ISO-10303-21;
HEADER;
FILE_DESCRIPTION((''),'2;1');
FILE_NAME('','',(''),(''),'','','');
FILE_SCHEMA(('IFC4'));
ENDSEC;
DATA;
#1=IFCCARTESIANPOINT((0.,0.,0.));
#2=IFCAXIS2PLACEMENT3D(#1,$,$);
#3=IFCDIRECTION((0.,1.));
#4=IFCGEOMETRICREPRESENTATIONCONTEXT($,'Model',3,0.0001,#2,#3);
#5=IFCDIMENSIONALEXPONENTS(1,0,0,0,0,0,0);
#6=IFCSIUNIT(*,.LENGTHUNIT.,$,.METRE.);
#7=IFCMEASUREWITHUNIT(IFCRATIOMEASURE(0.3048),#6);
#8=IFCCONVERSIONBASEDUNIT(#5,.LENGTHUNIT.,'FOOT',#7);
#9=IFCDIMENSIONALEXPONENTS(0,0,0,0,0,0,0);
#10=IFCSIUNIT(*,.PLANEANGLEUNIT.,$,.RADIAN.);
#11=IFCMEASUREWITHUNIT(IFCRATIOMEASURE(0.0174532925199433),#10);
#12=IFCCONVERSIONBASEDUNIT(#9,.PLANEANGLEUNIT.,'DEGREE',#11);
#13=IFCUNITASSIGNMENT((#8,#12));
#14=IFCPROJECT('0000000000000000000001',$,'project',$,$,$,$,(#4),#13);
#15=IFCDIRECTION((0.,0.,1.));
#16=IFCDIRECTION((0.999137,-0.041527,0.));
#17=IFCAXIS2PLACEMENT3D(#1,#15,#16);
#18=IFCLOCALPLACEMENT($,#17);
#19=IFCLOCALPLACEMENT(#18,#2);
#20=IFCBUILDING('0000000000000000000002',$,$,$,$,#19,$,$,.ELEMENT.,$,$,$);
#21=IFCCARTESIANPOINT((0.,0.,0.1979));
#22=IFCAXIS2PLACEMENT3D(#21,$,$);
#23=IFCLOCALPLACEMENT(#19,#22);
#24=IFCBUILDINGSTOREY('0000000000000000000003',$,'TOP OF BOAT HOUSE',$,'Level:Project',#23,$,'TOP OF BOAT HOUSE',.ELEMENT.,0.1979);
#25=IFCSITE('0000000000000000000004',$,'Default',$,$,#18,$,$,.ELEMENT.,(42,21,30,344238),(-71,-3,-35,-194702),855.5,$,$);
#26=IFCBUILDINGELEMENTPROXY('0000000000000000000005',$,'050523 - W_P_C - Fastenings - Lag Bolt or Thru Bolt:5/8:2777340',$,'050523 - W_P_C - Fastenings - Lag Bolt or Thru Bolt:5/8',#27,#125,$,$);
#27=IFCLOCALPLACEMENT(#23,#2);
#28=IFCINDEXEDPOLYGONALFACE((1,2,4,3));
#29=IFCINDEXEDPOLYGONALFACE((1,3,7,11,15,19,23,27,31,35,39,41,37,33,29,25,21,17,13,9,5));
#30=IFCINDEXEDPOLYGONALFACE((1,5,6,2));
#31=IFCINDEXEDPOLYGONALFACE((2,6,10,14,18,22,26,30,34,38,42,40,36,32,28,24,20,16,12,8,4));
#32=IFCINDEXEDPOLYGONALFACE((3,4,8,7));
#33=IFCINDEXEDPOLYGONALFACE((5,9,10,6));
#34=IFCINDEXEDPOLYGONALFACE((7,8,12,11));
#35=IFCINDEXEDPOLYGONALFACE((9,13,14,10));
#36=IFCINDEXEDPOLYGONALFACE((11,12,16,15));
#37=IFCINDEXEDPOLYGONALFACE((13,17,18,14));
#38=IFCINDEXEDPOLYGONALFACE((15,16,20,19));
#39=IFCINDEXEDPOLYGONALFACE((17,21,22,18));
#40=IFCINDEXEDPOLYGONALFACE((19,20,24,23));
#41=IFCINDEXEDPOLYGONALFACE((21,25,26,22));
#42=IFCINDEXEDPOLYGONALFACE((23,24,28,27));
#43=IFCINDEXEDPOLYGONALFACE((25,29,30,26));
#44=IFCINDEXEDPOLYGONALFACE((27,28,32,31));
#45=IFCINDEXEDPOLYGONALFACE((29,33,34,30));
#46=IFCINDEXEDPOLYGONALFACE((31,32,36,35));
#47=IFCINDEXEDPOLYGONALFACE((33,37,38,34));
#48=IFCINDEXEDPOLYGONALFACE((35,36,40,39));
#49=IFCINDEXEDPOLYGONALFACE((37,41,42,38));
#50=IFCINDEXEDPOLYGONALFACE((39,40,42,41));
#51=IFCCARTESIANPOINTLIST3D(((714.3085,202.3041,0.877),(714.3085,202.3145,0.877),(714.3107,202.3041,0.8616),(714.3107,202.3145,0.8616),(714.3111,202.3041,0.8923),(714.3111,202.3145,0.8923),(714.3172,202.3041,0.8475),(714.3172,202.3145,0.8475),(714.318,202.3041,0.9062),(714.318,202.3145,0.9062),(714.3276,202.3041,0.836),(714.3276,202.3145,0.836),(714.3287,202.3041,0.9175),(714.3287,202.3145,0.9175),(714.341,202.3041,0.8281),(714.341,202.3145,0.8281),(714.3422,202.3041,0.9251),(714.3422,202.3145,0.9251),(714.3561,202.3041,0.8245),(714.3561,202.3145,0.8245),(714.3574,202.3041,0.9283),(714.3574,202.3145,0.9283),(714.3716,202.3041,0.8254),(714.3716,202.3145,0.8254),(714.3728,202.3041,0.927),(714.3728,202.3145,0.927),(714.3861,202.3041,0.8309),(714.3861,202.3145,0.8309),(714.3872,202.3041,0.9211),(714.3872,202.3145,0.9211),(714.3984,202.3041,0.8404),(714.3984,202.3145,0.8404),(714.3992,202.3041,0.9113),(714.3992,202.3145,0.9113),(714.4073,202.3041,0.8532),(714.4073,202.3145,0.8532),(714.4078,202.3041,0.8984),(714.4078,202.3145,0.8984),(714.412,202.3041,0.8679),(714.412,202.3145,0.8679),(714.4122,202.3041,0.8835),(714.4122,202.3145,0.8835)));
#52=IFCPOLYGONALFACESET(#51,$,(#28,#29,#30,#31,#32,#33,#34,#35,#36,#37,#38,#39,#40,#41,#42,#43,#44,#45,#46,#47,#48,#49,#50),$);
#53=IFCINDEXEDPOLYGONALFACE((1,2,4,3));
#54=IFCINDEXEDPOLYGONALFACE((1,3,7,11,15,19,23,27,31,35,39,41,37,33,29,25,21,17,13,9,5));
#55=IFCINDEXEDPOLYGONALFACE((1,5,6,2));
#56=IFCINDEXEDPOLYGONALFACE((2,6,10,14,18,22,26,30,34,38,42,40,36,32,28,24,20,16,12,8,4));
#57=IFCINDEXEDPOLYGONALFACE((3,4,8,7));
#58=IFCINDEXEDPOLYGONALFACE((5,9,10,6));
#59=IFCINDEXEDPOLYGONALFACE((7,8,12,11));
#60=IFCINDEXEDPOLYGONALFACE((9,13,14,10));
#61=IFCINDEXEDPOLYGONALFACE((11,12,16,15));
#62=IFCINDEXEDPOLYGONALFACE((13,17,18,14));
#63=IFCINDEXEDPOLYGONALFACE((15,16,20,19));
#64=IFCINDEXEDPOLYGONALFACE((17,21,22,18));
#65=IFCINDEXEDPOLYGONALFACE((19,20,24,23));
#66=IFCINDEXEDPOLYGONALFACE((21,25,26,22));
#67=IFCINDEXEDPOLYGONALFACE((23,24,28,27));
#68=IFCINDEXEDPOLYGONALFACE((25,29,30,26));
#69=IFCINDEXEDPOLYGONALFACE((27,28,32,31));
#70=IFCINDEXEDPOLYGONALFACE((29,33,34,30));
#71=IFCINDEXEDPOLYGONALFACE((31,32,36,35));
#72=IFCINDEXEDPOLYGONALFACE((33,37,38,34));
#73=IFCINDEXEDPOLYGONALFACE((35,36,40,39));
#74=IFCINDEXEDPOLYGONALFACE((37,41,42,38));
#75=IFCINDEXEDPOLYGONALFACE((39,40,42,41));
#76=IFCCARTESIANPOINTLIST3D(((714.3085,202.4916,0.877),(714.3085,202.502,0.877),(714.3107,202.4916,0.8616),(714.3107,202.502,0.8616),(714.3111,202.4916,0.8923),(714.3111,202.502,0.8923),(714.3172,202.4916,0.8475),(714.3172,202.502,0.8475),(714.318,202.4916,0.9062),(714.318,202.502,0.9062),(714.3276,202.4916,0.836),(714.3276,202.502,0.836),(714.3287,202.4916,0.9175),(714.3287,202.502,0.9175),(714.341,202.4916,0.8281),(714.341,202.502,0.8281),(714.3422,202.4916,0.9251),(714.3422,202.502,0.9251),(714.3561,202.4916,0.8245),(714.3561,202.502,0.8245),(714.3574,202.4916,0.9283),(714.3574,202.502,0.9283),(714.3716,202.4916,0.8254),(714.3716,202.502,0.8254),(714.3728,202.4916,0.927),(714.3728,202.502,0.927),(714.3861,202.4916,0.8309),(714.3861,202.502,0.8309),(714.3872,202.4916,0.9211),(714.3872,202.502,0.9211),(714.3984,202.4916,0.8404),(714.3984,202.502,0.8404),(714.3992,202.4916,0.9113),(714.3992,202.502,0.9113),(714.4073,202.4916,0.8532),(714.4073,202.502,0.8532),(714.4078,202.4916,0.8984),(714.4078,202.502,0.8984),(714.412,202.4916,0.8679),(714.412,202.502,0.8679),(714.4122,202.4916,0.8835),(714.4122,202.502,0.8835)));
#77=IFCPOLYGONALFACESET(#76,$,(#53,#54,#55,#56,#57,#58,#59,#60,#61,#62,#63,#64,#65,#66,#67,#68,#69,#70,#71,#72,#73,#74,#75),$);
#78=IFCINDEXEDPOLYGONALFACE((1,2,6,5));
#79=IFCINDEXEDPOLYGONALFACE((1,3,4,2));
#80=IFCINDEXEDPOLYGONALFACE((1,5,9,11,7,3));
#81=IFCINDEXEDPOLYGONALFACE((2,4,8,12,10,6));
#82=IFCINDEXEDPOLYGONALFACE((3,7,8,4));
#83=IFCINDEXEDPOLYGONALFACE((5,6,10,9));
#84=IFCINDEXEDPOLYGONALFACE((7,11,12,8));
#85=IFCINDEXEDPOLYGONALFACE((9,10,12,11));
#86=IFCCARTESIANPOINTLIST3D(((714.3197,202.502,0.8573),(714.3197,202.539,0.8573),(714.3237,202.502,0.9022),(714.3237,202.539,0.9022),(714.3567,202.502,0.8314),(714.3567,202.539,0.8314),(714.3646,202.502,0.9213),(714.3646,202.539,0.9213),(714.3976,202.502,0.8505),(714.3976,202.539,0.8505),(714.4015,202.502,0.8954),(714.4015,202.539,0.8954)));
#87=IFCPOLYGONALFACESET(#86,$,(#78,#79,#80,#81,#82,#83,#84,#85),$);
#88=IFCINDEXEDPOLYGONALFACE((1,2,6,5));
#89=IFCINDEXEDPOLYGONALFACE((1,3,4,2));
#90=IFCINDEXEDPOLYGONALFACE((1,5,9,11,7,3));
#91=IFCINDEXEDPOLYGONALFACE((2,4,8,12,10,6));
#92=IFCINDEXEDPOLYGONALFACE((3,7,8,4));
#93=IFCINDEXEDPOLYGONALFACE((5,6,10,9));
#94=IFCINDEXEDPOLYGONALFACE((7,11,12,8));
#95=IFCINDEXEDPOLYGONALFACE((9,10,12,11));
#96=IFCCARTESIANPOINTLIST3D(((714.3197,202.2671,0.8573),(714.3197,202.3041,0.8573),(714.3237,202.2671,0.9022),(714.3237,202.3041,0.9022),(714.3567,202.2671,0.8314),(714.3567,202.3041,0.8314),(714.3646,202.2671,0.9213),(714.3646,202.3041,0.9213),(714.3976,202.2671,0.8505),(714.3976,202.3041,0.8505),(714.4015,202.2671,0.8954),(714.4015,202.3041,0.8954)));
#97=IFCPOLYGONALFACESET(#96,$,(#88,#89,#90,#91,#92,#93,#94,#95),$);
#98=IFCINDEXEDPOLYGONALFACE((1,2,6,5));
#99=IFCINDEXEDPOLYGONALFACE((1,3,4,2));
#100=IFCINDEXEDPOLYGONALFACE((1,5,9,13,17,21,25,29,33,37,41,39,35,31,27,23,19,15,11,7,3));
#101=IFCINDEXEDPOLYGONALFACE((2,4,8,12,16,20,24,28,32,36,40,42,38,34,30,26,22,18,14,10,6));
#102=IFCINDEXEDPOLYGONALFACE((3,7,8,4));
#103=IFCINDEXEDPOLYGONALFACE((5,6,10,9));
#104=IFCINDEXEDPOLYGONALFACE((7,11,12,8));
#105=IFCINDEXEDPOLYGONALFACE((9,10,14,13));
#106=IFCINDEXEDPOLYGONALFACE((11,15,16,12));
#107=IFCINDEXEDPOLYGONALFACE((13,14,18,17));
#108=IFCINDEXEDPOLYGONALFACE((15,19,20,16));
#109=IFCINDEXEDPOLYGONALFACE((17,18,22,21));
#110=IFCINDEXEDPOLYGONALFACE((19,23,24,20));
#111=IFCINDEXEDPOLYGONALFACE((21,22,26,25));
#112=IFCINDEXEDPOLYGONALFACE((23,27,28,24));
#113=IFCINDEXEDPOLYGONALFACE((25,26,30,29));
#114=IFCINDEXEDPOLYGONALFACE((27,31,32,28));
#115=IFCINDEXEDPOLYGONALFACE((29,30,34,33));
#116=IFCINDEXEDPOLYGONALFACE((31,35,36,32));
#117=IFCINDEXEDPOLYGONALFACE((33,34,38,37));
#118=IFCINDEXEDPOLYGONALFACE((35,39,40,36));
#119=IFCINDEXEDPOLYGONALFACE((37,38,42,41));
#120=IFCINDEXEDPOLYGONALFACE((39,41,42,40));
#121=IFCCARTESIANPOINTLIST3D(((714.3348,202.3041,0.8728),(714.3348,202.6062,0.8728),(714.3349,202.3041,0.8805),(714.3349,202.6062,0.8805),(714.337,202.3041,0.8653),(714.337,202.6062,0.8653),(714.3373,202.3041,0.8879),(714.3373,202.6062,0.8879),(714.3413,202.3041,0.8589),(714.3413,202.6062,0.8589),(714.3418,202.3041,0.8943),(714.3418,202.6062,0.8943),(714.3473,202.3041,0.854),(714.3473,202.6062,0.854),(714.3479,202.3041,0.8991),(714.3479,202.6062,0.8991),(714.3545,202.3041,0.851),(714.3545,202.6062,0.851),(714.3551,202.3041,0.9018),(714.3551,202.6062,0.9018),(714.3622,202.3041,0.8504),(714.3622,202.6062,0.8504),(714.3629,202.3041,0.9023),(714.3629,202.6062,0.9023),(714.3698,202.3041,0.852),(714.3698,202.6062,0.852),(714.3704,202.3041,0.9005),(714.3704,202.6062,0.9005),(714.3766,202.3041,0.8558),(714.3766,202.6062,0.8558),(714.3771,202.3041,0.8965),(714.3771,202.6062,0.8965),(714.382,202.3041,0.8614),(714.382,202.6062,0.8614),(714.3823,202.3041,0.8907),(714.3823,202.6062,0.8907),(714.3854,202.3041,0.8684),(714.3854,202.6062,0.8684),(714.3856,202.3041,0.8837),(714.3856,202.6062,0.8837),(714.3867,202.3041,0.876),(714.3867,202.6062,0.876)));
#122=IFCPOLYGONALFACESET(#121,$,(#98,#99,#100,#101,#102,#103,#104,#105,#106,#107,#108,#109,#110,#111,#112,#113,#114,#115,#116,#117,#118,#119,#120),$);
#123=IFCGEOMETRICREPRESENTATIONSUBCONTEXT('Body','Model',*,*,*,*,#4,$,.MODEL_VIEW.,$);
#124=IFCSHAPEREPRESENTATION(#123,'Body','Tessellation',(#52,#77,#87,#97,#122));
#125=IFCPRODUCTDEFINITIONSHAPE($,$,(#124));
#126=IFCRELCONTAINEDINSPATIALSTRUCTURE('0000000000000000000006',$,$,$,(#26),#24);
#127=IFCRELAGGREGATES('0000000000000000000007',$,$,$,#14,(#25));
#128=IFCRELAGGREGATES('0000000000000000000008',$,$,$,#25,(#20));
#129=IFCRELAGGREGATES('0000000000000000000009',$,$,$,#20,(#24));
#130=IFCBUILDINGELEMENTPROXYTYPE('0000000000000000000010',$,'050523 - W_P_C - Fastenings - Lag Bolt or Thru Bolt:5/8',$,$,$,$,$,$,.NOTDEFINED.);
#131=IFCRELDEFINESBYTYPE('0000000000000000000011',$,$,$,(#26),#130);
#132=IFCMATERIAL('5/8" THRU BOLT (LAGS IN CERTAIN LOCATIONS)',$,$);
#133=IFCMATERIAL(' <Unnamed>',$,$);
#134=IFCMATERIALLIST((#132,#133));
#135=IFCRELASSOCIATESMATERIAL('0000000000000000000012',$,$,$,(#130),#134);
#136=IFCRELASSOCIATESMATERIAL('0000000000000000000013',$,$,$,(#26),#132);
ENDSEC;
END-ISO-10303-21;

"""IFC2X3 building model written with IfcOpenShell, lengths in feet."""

from ifc_helpers import new_model, entity, si_unit, converted_unit, direction, frame, frame_2d, origin, place, context, subcontext, project, spatial, polyline, circle, outline, extrude, source, transform, mapped, material, material_list, type_object, type_shapes, element, save


model = new_model("IFC2X3")

# Units and contexts
model_context = context("Model", 3, precision=0.0001, world=origin(), true_north=direction((0.0, 1.0)))
body_context = subcontext(model_context, "Body", "Model", "MODEL_VIEW")
ifc_project = project(units=[converted_unit("LENGTHUNIT", "FOOT", entity("IfcRatioMeasure", 0.3048), si_unit("LENGTHUNIT", "METRE"), dimensions=[1, 0, 0, 0, 0, 0, 0]), converted_unit("PLANEANGLEUNIT", "DEGREE", entity("IfcRatioMeasure", 0.0174532925199433), si_unit("PLANEANGLEUNIT", "RADIAN"), dimensions=[0, 0, 0, 0, 0, 0, 0])], contexts=[model_context])

# Site, building, storey
site_placement = place(None, frame((0.0, 0.0, 0.0), z_axis=(0.0, 0.0, 1.0), x_axis=(0.999137, -0.041527, 0.0)))
site = spatial("IfcSite", under=ifc_project, at=site_placement, Name="Default", CompositionType="ELEMENT", RefLatitude=(42, 21, 30, 344238), RefLongitude=(-71, -3, -35, -194702), RefElevation=855.5)
building_placement = place(site_placement, origin())
building = spatial("IfcBuilding", under=site, at=building_placement, CompositionType="ELEMENT")
storey_placement = place(building_placement, frame((0.0, 0.0, 0.1979)))
storey = spatial("IfcBuildingStorey", under=building, at=storey_placement, Name="TOP OF BOAT HOUSE", ObjectType="Level:Project", LongName="TOP OF BOAT HOUSE", CompositionType="ELEMENT", Elevation=0.1979)

# Building element proxy
ifc_material_1 = material(Name="5/8\" THRU BOLT (LAGS IN CERTAIN LOCATIONS)")
ifc_material_2 = material(Name=" <Unnamed>")
ifc_material_list_1 = material_list([ifc_material_1, ifc_material_2])
building_element_proxy_type_1 = type_object("IfcBuildingElementProxyType", Name="050523 - W_P_C - Fastenings - Lag Bolt or Thru Bolt:5/8", PredefinedType="NOTDEFINED", material=ifc_material_list_1)
shared_shape_1 = source(origin(), body_context, "Body", "SweptSolid", [
    extrude(circle(Radius=0.0521, at=frame_2d((0.0, 0.0), x_axis=(1.0, 0.0))), frame((0.0, 0.0, 0.0), z_axis=(0.0, 0.0, 1.0), x_axis=(0.0, -1.0, 0.0)), (0.0, 0.0, 1.0), 0.0104),
    extrude(circle(Radius=0.0521, at=frame_2d((0.0, 0.0), x_axis=(1.0, 0.0))), frame((0.0, 0.0, -0.1875), z_axis=(0.0, 0.0, 1.0), x_axis=(0.0, -1.0, 0.0)), (0.0, 0.0, 1.0), 0.0104),
    extrude(outline(polyline([(-0.0226, -0.0391), (0.0226, -0.0391), (0.0451, 0.0), (0.0226, 0.0391), (-0.0226, 0.0391), (-0.0451, 0.0), (-0.0226, -0.0391)])), frame((0.0, 0.0, -0.2245), z_axis=(0.0, 0.0, 1.0), x_axis=(0.866025, -0.5, 0.0)), (0.0, 0.0, 1.0), 0.037),
    extrude(outline(polyline([(-0.0226, -0.0391), (0.0226, -0.0391), (0.0451, 0.0), (0.0226, 0.0391), (-0.0226, 0.0391), (-0.0451, 0.0), (-0.0226, -0.0391)])), frame((0.0, 0.0, 0.0104), z_axis=(0.0, 0.0, 1.0), x_axis=(0.0, -1.0, 0.0)), (0.0, 0.0, 1.0), 0.037),
    extrude(circle(Radius=0.026, at=frame_2d((0.0, 0.0), x_axis=(1.0, 0.0))), frame((0.0, 0.0, -0.2917), z_axis=(0.0, 0.0, 1.0), x_axis=(0.0, 1.0, 0.0)), (0.0, 0.0, 1.0), 0.3021),
])
type_shapes(building_element_proxy_type_1, [shared_shape_1])
for number, where, z_axis, x_axis, name in (
    (1, (714.3606, 202.3145, 0.8763), (0.0, -1.0, 0.0), (0.996195, 0.0, -0.087156), "050523 - W_P_C - Fastenings - Lag Bolt or Thru Bolt:5/8:2777340"),
):
    element("IfcBuildingElementProxy", number, at=place(storey_placement, frame(where, z_axis=z_axis, x_axis=x_axis)), inside=storey, type_object=building_element_proxy_type_1, material=ifc_material_1, Name=name, ObjectType="050523 - W_P_C - Fastenings - Lag Bolt or Thru Bolt:5/8", context=body_context, shape_type="MappedRepresentation", body=[
        mapped(shared_shape_1, transform((0.0, 0.0, 0.0), scale=1.0)),
    ])

save(model, "model.ifc")
